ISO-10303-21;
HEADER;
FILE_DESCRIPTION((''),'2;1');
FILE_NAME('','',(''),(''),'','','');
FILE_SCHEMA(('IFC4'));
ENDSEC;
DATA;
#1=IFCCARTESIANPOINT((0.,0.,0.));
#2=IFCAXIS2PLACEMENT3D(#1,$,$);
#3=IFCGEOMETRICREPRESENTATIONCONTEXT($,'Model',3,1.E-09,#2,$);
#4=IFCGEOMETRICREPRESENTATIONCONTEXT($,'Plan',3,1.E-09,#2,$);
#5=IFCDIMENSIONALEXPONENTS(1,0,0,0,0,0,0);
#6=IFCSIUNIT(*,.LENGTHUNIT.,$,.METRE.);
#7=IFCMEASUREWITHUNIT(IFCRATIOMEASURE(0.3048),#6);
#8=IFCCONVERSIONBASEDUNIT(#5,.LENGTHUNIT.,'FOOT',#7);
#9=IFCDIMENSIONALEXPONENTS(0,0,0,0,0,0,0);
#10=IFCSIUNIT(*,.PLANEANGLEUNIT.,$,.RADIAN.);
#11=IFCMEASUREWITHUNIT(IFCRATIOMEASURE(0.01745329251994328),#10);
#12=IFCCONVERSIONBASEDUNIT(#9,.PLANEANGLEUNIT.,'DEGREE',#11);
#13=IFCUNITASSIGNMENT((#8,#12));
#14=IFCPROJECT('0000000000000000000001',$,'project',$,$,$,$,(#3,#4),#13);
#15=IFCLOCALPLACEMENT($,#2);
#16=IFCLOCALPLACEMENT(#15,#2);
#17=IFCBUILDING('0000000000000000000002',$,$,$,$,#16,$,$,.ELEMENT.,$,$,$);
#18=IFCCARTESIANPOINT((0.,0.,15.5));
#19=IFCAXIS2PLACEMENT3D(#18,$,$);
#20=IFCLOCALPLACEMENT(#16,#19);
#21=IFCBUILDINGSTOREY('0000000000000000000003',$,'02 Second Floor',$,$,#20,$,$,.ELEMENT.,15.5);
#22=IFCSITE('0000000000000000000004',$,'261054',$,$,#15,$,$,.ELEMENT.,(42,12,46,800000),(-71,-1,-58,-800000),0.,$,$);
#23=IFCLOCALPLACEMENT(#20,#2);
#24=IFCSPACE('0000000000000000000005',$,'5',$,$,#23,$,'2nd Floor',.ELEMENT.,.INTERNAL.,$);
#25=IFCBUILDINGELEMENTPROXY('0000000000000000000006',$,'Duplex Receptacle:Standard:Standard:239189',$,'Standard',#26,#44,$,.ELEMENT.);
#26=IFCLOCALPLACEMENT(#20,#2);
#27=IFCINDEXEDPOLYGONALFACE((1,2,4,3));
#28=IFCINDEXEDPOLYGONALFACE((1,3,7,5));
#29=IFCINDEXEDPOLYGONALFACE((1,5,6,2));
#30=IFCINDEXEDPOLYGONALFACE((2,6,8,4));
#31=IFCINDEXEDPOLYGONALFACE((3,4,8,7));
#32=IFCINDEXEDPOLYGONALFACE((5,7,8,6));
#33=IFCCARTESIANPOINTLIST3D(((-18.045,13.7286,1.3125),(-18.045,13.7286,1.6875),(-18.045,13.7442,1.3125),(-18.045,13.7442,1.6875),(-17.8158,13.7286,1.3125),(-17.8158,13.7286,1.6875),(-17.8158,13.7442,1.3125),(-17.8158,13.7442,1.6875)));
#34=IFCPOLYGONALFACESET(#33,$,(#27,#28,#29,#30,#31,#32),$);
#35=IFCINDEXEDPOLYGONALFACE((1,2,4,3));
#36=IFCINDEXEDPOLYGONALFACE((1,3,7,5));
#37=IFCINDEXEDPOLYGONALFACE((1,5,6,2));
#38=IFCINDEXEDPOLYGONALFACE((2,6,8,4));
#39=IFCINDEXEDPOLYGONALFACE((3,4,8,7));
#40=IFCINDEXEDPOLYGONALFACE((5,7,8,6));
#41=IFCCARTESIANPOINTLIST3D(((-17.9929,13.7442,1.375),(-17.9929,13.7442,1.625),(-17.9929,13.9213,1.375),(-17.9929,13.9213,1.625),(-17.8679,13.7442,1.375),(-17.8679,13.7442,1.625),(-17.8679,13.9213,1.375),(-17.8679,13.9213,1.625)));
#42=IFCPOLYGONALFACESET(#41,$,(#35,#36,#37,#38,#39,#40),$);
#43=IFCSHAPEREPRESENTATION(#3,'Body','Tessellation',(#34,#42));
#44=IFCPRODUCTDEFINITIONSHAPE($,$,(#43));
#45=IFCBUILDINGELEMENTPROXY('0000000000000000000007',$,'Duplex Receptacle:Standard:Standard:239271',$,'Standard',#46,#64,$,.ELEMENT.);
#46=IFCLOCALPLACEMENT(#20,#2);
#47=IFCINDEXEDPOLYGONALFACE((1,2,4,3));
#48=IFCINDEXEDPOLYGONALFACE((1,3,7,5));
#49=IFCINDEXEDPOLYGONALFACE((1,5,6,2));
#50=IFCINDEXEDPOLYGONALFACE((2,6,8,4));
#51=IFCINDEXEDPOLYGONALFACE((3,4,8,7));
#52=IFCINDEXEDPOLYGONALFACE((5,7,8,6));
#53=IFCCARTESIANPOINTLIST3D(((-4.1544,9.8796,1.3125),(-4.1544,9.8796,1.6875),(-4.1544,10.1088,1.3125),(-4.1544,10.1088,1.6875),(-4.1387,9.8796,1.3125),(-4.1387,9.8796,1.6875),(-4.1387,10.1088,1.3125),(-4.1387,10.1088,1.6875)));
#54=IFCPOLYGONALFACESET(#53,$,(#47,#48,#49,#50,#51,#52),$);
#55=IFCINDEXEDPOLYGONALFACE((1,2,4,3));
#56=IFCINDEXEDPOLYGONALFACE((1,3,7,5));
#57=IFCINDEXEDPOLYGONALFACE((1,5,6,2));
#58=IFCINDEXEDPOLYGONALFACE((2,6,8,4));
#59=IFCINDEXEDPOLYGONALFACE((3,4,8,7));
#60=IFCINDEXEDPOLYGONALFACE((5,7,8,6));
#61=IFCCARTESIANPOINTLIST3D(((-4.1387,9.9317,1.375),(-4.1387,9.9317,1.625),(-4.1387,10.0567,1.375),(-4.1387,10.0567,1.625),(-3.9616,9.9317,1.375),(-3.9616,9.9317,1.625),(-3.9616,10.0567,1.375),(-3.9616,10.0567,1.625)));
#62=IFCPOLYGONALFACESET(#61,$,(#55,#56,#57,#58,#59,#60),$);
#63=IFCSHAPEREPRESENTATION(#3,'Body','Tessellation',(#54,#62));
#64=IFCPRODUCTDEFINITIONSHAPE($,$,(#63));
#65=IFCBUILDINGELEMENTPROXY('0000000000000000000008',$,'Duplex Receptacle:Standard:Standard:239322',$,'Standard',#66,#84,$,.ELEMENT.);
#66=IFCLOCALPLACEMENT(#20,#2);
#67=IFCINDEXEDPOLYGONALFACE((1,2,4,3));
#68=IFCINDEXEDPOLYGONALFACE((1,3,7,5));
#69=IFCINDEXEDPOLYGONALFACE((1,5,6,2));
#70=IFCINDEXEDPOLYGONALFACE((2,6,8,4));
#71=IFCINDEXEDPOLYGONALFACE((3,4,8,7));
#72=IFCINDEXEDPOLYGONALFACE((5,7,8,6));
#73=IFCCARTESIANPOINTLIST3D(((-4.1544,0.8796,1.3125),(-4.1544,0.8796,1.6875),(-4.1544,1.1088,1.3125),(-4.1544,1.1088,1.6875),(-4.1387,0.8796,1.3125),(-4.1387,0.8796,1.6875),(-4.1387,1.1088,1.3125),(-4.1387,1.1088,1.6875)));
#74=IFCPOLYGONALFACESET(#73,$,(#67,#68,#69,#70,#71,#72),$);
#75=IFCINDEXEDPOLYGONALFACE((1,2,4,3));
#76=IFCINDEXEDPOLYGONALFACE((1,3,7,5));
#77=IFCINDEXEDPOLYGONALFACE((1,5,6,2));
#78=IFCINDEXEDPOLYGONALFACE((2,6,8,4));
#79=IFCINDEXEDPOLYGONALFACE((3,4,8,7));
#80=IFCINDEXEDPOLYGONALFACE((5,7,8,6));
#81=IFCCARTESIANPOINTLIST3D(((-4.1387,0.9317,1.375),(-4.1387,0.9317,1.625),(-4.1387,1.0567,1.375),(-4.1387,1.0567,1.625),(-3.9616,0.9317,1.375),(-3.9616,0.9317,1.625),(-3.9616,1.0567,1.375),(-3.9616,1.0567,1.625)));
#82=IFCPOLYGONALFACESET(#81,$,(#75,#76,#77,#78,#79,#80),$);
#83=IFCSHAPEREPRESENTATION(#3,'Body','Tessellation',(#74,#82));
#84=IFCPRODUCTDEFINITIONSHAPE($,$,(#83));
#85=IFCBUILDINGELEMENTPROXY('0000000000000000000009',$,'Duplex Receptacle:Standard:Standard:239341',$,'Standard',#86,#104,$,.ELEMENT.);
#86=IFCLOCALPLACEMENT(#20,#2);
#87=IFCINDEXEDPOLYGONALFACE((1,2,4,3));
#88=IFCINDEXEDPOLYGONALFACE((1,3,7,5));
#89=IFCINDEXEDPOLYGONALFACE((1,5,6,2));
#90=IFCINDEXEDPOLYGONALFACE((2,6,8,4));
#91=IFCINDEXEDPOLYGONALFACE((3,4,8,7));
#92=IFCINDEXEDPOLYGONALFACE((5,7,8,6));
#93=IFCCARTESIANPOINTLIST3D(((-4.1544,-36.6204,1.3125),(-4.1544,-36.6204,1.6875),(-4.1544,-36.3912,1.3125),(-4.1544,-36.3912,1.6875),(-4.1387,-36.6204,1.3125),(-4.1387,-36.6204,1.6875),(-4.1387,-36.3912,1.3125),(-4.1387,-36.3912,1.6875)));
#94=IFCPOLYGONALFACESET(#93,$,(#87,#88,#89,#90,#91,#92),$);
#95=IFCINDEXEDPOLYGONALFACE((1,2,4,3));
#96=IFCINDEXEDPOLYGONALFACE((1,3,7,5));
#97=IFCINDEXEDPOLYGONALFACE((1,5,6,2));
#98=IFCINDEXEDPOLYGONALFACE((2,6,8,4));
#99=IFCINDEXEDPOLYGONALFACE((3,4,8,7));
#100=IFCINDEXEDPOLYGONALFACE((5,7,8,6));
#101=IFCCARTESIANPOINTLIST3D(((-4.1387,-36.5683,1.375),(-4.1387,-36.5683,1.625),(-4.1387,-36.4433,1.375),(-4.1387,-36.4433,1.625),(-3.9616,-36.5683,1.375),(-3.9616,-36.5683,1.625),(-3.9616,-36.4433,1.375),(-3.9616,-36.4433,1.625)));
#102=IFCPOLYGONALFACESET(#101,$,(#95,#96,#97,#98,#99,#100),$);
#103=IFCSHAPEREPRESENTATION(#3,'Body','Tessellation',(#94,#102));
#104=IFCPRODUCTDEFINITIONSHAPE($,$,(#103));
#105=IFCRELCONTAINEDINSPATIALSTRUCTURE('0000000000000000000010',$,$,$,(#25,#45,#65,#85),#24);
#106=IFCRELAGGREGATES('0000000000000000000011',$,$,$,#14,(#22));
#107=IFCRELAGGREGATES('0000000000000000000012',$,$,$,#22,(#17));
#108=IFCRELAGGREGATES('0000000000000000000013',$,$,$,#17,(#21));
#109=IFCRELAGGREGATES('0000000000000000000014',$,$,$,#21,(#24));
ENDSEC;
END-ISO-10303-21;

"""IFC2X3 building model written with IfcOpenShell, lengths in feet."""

from ifc_helpers import new_model, entity, si_unit, converted_unit, frame, origin, origin_2d_with_axis, place, context, project, spatial, rectangle, extrude, source, transform, mapped, element, save


model = new_model("IFC2X3")

# Units and contexts
model_context = context("Model", 3, precision=1e-09, world=origin())
plan_context = context("Plan", 3, precision=1e-09, world=origin())
ifc_project = project(units=[converted_unit("LENGTHUNIT", "FOOT", entity("IfcRatioMeasure", 0.3048), si_unit("LENGTHUNIT", "METRE"), dimensions=[1, 0, 0, 0, 0, 0, 0]), converted_unit("PLANEANGLEUNIT", "DEGREE", entity("IfcRatioMeasure", 0.01745329251994328), si_unit("PLANEANGLEUNIT", "RADIAN"), dimensions=[0, 0, 0, 0, 0, 0, 0])], contexts=[model_context, plan_context])

# Site, building, storey
site_placement = place(None, origin())
site = spatial("IfcSite", under=ifc_project, at=site_placement, Name="261054", CompositionType="ELEMENT", RefLatitude=(42, 12, 46, 800000), RefLongitude=(-71, -1, -58, -800000), RefElevation=0.0)
building_placement = place(site_placement, origin())
building = spatial("IfcBuilding", under=site, at=building_placement, CompositionType="ELEMENT")
storey_placement = place(building_placement, frame((0.0, 0.0, 15.5)))
storey = spatial("IfcBuildingStorey", under=building, at=storey_placement, Name="02 Second Floor", CompositionType="ELEMENT", Elevation=15.5)

# Shared definitions
space_placement = place(storey_placement, origin())
space = spatial("IfcSpace", under=storey, at=space_placement, Name="5", LongName="2nd Floor", CompositionType="ELEMENT", InteriorOrExteriorSpace="INTERNAL")

# Building element proxies
shared_shape_1 = source(origin(), model_context, "Body", "SweptSolid", [
    extrude(rectangle(XDim=0.2292, YDim=0.375, at=origin_2d_with_axis()), frame((0.0, 0.0, 0.0), z_axis=(0.0, 0.0, 1.0), x_axis=(-1.0, 0.0, 0.0)), (0.0, 0.0, 1.0), 0.0156),
    extrude(rectangle(XDim=0.125, YDim=0.25, at=origin_2d_with_axis()), frame((0.0, 0.0, -0.1771), z_axis=(0.0, 0.0, 1.0), x_axis=(-1.0, 0.0, 0.0)), (0.0, 0.0, 1.0), 0.1771),
])
for number, where, z_axis, x_axis, name in (
    (1, (-17.9304, 13.7442, 1.5), (0.0, -1.0, 0.0), (1.0, 0.0, 0.0), "Duplex Receptacle:Standard:Standard:239189"),
    (2, (-4.1387, 9.9942, 1.5), (-1.0, 0.0, 0.0), (0.0, -1.0, 0.0), "Duplex Receptacle:Standard:Standard:239271"),
    (3, (-4.1387, 0.9942, 1.5), (-1.0, 0.0, 0.0), (0.0, -1.0, 0.0), "Duplex Receptacle:Standard:Standard:239322"),
    (4, (-4.1387, -36.5058, 1.5), (-1.0, 0.0, 0.0), (0.0, -1.0, 0.0), "Duplex Receptacle:Standard:Standard:239341"),
):
    element("IfcBuildingElementProxy", number, at=place(space_placement, frame(where, z_axis=z_axis, x_axis=x_axis)), inside=space, Name=name, ObjectType="Standard", CompositionType="ELEMENT", context=model_context, shape_type="MappedRepresentation", body=[
        mapped(shared_shape_1, transform((0.0, 0.0, 0.0), scale=1.0)),
    ])

save(model, "model.ifc")
